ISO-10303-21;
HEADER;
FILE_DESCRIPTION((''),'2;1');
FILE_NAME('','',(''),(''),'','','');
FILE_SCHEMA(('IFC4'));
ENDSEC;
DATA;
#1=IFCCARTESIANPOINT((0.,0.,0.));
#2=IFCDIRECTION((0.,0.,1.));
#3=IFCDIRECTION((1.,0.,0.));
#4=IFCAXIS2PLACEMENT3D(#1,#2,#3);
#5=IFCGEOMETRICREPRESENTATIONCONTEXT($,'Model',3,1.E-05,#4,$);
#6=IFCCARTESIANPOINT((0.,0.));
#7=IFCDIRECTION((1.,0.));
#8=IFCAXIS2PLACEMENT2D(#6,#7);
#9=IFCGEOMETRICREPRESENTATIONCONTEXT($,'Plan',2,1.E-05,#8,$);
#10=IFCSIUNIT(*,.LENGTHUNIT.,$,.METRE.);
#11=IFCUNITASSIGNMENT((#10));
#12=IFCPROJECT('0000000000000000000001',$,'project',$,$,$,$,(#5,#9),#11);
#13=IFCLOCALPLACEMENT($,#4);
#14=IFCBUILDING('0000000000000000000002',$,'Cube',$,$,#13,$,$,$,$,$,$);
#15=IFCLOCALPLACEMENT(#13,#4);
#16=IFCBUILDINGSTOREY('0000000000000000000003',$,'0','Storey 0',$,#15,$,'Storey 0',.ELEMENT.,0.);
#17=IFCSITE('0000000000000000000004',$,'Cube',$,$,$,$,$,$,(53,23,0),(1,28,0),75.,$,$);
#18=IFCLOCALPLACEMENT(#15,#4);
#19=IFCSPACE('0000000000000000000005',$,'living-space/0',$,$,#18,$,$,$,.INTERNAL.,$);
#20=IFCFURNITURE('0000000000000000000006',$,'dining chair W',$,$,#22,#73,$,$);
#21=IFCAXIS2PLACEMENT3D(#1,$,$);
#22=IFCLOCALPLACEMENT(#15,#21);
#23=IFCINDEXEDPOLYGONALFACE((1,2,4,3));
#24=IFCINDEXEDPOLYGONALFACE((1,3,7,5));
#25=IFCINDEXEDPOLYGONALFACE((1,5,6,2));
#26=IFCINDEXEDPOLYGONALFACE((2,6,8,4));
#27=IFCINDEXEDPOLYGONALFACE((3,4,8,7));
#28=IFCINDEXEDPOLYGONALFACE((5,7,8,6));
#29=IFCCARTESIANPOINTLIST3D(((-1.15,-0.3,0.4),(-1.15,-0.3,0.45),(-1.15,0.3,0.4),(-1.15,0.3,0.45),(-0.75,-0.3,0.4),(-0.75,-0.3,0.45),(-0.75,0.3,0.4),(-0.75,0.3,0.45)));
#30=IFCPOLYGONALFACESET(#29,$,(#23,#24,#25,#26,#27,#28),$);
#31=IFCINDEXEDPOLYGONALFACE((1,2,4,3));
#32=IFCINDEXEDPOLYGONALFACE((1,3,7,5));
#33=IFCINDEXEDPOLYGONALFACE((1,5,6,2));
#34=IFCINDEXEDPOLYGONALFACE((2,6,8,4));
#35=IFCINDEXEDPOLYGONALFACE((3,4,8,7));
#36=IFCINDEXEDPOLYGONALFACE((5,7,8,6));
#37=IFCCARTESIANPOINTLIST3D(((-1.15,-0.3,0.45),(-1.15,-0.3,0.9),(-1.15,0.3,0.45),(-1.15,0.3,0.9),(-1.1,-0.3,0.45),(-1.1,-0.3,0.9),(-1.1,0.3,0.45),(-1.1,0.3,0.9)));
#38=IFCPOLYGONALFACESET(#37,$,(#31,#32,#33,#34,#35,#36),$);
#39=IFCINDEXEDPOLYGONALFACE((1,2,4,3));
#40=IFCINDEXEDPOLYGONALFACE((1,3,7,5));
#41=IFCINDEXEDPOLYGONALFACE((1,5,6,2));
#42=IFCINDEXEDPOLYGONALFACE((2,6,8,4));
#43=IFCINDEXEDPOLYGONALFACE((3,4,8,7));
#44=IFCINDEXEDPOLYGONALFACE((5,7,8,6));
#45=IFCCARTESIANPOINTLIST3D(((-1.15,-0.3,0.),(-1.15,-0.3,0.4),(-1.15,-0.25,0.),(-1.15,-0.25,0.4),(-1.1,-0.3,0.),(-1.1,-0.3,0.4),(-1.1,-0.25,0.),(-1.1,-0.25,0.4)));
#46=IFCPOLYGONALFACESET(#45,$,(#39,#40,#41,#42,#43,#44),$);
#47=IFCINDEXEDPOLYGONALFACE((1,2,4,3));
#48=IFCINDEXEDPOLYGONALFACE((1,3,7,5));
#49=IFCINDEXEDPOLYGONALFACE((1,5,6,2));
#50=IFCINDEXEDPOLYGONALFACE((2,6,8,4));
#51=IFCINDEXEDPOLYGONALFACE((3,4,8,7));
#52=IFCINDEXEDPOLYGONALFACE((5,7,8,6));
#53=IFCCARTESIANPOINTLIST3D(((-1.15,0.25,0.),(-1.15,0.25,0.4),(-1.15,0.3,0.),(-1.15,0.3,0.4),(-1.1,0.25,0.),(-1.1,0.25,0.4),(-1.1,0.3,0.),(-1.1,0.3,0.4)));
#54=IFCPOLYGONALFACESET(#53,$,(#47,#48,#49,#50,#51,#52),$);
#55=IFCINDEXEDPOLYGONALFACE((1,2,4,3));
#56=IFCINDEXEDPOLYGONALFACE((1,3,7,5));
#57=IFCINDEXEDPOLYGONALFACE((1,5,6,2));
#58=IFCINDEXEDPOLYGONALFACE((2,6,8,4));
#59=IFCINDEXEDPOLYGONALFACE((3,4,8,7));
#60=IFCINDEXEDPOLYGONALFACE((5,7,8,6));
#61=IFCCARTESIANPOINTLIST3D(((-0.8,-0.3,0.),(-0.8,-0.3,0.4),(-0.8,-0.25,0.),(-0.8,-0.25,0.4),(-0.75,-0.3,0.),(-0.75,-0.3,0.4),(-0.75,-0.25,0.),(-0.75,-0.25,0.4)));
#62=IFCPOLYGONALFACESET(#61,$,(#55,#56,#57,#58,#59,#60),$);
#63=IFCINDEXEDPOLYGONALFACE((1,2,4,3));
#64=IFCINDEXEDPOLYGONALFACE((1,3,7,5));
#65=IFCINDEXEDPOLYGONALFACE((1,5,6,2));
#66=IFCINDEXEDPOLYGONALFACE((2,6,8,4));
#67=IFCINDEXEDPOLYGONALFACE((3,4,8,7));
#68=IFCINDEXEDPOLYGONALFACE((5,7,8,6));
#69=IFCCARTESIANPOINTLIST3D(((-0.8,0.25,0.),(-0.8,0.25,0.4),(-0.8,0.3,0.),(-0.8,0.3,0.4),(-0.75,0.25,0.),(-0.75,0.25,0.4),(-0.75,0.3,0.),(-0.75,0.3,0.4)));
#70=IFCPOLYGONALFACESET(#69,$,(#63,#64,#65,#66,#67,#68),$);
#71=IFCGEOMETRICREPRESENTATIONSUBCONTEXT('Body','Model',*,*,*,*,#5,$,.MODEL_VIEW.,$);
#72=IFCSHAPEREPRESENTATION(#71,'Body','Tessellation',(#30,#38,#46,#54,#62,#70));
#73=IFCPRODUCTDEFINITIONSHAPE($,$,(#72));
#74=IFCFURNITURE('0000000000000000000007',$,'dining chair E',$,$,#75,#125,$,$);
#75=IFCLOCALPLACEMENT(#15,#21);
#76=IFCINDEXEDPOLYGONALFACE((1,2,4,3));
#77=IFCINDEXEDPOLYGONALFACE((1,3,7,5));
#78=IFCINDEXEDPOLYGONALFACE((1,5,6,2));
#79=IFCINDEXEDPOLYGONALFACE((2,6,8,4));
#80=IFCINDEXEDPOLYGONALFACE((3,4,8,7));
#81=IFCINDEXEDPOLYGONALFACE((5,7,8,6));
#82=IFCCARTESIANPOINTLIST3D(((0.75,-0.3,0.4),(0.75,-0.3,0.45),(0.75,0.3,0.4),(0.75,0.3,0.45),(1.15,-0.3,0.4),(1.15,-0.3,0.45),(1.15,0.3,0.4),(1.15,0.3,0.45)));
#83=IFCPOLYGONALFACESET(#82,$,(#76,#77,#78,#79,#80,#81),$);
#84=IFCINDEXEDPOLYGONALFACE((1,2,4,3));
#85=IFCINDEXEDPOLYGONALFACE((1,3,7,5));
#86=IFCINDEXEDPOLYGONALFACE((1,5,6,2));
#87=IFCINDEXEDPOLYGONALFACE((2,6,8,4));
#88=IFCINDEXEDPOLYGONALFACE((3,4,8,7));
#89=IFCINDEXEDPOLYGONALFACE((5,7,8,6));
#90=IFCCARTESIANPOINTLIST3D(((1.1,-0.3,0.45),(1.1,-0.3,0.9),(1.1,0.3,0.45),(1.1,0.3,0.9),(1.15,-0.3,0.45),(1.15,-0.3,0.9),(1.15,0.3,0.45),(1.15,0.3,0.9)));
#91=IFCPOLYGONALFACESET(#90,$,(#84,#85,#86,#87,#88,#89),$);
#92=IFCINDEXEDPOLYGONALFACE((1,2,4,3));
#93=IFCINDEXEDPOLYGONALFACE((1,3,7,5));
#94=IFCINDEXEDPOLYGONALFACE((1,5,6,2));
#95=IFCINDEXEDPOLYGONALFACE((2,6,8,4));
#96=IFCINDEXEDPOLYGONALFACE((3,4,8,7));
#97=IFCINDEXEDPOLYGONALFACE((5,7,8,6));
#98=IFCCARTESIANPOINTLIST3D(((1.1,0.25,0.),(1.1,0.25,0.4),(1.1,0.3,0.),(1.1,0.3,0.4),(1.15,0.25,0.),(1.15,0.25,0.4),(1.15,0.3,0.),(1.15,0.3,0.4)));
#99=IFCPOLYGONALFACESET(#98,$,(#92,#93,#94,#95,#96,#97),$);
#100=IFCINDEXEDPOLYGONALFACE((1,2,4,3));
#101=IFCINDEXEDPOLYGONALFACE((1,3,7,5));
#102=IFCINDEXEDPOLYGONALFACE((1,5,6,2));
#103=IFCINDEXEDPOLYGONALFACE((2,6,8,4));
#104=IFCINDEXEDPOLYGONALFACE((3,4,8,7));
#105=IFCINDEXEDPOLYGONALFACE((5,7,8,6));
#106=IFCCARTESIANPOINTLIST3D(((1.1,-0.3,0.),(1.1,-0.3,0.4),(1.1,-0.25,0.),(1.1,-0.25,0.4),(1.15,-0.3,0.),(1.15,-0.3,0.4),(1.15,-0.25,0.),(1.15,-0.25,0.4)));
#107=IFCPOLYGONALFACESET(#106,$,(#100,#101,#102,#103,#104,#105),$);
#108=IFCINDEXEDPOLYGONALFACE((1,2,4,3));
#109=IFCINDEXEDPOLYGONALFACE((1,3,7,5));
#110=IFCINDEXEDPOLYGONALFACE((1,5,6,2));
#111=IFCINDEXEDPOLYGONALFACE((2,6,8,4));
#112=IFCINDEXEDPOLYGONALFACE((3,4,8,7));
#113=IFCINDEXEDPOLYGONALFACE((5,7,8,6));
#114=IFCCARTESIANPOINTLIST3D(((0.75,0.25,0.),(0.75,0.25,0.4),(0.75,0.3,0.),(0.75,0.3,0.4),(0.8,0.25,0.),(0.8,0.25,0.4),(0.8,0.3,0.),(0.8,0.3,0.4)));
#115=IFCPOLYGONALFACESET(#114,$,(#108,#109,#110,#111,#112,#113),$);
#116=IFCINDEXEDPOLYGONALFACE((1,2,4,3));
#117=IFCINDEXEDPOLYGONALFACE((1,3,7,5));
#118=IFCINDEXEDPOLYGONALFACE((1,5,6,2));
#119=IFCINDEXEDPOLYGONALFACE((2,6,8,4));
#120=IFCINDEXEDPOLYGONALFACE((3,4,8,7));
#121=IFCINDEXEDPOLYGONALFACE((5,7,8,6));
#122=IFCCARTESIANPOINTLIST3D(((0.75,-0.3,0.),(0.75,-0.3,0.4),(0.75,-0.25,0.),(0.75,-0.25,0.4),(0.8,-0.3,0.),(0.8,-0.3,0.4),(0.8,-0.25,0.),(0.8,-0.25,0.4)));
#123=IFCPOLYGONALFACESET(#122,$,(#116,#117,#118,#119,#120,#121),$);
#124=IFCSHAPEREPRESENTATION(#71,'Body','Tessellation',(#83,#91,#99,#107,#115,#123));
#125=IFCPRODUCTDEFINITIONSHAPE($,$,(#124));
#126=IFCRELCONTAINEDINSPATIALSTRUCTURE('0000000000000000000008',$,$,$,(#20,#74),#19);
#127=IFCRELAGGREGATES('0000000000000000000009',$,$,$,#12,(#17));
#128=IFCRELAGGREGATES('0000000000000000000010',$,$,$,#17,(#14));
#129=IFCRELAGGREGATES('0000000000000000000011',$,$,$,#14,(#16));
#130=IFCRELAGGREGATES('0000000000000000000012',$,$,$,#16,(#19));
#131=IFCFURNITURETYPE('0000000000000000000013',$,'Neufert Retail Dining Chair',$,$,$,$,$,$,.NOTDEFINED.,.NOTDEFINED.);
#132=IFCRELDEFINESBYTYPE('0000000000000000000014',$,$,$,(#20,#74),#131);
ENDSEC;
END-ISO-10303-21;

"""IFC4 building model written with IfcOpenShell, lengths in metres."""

from ifc_helpers import new_model, entity, si_unit, frame, origin_with_axes, origin_2d_with_axis, place, context, subcontext, project, spatial, line, indexed_curve, outline, extrude, shape, source, transform, mapped, type_object, type_shapes, element, save


model = new_model("IFC4")

# Units and contexts
model_context = context("Model", 3, precision=1e-05, world=origin_with_axes())
plan_context = context("Plan", 2, precision=1e-05, world=origin_2d_with_axis())
body_context_1 = subcontext(model_context, "Body", "Model", "MODEL_VIEW")
body_context_2 = subcontext(plan_context, "Body", "Plan", "PLAN_VIEW")
ifc_project = project(units=[si_unit("LENGTHUNIT", "METRE")], contexts=[model_context, plan_context])

# Site, building, storey
site = spatial("IfcSite", under=ifc_project, Name="Cube", RefLatitude=(53, 23, 0), RefLongitude=(1, 28, 0), RefElevation=75.0)
building_placement = place(None, origin_with_axes())
building = spatial("IfcBuilding", under=site, at=building_placement, Name="Cube")
storey_placement = place(building_placement, origin_with_axes())
storey = spatial("IfcBuildingStorey", under=building, at=storey_placement, Name="0", Description="Storey 0", LongName="Storey 0", CompositionType="ELEMENT", Elevation=0.0)

# Shared definitions
space_placement = place(storey_placement, origin_with_axes())
space = spatial("IfcSpace", under=storey, at=space_placement, Name="living-space/0", PredefinedType="INTERNAL")

# Furniture
furniture_type_1 = type_object("IfcFurnitureType", Name="Neufert Retail Dining Chair", AssemblyPlace="NOTDEFINED", PredefinedType="NOTDEFINED")
shared_shape_1 = source(origin_with_axes(), body_context_1, "Body", "SweptSolid", [
    extrude(outline(indexed_curve([(-0.3, 0.0), (0.3, 0.0), (0.3, -0.4), (-0.3, -0.4)], segments=[line(1, 2, 3, 4, 1)])), frame((0.0, 0.0, 0.45), z_axis=(0.0, 0.0, 1.0), x_axis=(1.0, 0.0, 0.0)), (0.0, 0.0, -1.0), 0.05),
    extrude(outline(indexed_curve([(-0.3, 0.0), (0.3, 0.0), (0.3, -0.05), (-0.3, -0.05)], segments=[line(1, 2, 3, 4, 1)])), frame((0.0, 0.0, 0.9), z_axis=(0.0, 0.0, 1.0), x_axis=(1.0, 0.0, 0.0)), (0.0, 0.0, -1.0), 0.45),
    extrude(outline(indexed_curve([(-0.3, 0.0), (-0.25, 0.0), (-0.25, -0.05), (-0.3, -0.05)], segments=[line(1, 2, 3, 4, 1)])), origin_with_axes(), (0.0, 0.0, 1.0), 0.4),
    extrude(outline(indexed_curve([(0.3, 0.0), (0.25, 0.0), (0.25, -0.05), (0.3, -0.05)], segments=[line(1, 2, 3, 4, 1)])), origin_with_axes(), (0.0, 0.0, 1.0), 0.4),
    extrude(outline(indexed_curve([(-0.3, -0.4), (-0.25, -0.4), (-0.25, -0.35), (-0.3, -0.35)], segments=[line(1, 2, 3, 4, 1)])), origin_with_axes(), (0.0, 0.0, 1.0), 0.4),
    extrude(outline(indexed_curve([(0.3, -0.4), (0.25, -0.4), (0.25, -0.35), (0.3, -0.35)], segments=[line(1, 2, 3, 4, 1)])), origin_with_axes(), (0.0, 0.0, 1.0), 0.4),
])
shared_shape_2 = source(origin_with_axes(), body_context_2, "Body", "Curve2D", [
    entity("IfcIndexedPolyCurve", entity("IfcCartesianPointList2D", [[-0.3, -0.4], [0.3, -0.4]])),
    entity("IfcIndexedPolyCurve", entity("IfcCartesianPointList2D", [[-0.3, -0.4], [-0.3, -0.3], [-0.2121, -0.0879], [0.0, 0.0], [0.2121, -0.0879], [0.3, -0.3], [0.3, -0.4]]), [entity("IfcLineIndex", [1, 2]), entity("IfcArcIndex", [2, 3, 4]), entity("IfcArcIndex", [4, 5, 6]), entity("IfcLineIndex", [6, 7])]),
    entity("IfcIndexedPolyCurve", entity("IfcCartesianPointList2D", [[-0.26, -0.4], [-0.26, -0.3], [-0.1838, -0.1162], [0.0, -0.04], [0.1838, -0.1162], [0.26, -0.3], [0.26, -0.4]]), [entity("IfcLineIndex", [1, 2]), entity("IfcArcIndex", [2, 3, 4]), entity("IfcArcIndex", [4, 5, 6]), entity("IfcLineIndex", [6, 7])]),
])
type_shapes(furniture_type_1, [shared_shape_1, shared_shape_2])
for number, where, z_axis, x_axis, name in (
    (1, (-1.15, 0.0, 0.0), (0.0, 0.0, 1.0), (0.0, 1.0, 0.0), "dining chair W"),
    (2, (1.15, 0.0, 0.0), (0.0, 0.0, 1.0), (0.0, -1.0, 0.0), "dining chair E"),
):
    element("IfcFurniture", number, at=place(space_placement, frame(where, z_axis=z_axis, x_axis=x_axis)), inside=space, type_object=furniture_type_1, Name=name, shapes=[
        shape(body_context_1, "Body", "MappedRepresentation", [mapped(shared_shape_1, transform((0.0, 0.0, 0.0), x_axis=(1.0, 0.0, 0.0), y_axis=(0.0, 1.0, 0.0), z_axis=(0.0, 0.0, 1.0), scale=1.0))]),
        shape(body_context_2, "Body", "MappedRepresentation", [mapped(shared_shape_2, transform((0.0, 0.0, 0.0), x_axis=(1.0, 0.0, 0.0), y_axis=(0.0, 1.0, 0.0), z_axis=(0.0, 0.0, 1.0), scale=1.0))]),
    ])

save(model, "model.ifc")
